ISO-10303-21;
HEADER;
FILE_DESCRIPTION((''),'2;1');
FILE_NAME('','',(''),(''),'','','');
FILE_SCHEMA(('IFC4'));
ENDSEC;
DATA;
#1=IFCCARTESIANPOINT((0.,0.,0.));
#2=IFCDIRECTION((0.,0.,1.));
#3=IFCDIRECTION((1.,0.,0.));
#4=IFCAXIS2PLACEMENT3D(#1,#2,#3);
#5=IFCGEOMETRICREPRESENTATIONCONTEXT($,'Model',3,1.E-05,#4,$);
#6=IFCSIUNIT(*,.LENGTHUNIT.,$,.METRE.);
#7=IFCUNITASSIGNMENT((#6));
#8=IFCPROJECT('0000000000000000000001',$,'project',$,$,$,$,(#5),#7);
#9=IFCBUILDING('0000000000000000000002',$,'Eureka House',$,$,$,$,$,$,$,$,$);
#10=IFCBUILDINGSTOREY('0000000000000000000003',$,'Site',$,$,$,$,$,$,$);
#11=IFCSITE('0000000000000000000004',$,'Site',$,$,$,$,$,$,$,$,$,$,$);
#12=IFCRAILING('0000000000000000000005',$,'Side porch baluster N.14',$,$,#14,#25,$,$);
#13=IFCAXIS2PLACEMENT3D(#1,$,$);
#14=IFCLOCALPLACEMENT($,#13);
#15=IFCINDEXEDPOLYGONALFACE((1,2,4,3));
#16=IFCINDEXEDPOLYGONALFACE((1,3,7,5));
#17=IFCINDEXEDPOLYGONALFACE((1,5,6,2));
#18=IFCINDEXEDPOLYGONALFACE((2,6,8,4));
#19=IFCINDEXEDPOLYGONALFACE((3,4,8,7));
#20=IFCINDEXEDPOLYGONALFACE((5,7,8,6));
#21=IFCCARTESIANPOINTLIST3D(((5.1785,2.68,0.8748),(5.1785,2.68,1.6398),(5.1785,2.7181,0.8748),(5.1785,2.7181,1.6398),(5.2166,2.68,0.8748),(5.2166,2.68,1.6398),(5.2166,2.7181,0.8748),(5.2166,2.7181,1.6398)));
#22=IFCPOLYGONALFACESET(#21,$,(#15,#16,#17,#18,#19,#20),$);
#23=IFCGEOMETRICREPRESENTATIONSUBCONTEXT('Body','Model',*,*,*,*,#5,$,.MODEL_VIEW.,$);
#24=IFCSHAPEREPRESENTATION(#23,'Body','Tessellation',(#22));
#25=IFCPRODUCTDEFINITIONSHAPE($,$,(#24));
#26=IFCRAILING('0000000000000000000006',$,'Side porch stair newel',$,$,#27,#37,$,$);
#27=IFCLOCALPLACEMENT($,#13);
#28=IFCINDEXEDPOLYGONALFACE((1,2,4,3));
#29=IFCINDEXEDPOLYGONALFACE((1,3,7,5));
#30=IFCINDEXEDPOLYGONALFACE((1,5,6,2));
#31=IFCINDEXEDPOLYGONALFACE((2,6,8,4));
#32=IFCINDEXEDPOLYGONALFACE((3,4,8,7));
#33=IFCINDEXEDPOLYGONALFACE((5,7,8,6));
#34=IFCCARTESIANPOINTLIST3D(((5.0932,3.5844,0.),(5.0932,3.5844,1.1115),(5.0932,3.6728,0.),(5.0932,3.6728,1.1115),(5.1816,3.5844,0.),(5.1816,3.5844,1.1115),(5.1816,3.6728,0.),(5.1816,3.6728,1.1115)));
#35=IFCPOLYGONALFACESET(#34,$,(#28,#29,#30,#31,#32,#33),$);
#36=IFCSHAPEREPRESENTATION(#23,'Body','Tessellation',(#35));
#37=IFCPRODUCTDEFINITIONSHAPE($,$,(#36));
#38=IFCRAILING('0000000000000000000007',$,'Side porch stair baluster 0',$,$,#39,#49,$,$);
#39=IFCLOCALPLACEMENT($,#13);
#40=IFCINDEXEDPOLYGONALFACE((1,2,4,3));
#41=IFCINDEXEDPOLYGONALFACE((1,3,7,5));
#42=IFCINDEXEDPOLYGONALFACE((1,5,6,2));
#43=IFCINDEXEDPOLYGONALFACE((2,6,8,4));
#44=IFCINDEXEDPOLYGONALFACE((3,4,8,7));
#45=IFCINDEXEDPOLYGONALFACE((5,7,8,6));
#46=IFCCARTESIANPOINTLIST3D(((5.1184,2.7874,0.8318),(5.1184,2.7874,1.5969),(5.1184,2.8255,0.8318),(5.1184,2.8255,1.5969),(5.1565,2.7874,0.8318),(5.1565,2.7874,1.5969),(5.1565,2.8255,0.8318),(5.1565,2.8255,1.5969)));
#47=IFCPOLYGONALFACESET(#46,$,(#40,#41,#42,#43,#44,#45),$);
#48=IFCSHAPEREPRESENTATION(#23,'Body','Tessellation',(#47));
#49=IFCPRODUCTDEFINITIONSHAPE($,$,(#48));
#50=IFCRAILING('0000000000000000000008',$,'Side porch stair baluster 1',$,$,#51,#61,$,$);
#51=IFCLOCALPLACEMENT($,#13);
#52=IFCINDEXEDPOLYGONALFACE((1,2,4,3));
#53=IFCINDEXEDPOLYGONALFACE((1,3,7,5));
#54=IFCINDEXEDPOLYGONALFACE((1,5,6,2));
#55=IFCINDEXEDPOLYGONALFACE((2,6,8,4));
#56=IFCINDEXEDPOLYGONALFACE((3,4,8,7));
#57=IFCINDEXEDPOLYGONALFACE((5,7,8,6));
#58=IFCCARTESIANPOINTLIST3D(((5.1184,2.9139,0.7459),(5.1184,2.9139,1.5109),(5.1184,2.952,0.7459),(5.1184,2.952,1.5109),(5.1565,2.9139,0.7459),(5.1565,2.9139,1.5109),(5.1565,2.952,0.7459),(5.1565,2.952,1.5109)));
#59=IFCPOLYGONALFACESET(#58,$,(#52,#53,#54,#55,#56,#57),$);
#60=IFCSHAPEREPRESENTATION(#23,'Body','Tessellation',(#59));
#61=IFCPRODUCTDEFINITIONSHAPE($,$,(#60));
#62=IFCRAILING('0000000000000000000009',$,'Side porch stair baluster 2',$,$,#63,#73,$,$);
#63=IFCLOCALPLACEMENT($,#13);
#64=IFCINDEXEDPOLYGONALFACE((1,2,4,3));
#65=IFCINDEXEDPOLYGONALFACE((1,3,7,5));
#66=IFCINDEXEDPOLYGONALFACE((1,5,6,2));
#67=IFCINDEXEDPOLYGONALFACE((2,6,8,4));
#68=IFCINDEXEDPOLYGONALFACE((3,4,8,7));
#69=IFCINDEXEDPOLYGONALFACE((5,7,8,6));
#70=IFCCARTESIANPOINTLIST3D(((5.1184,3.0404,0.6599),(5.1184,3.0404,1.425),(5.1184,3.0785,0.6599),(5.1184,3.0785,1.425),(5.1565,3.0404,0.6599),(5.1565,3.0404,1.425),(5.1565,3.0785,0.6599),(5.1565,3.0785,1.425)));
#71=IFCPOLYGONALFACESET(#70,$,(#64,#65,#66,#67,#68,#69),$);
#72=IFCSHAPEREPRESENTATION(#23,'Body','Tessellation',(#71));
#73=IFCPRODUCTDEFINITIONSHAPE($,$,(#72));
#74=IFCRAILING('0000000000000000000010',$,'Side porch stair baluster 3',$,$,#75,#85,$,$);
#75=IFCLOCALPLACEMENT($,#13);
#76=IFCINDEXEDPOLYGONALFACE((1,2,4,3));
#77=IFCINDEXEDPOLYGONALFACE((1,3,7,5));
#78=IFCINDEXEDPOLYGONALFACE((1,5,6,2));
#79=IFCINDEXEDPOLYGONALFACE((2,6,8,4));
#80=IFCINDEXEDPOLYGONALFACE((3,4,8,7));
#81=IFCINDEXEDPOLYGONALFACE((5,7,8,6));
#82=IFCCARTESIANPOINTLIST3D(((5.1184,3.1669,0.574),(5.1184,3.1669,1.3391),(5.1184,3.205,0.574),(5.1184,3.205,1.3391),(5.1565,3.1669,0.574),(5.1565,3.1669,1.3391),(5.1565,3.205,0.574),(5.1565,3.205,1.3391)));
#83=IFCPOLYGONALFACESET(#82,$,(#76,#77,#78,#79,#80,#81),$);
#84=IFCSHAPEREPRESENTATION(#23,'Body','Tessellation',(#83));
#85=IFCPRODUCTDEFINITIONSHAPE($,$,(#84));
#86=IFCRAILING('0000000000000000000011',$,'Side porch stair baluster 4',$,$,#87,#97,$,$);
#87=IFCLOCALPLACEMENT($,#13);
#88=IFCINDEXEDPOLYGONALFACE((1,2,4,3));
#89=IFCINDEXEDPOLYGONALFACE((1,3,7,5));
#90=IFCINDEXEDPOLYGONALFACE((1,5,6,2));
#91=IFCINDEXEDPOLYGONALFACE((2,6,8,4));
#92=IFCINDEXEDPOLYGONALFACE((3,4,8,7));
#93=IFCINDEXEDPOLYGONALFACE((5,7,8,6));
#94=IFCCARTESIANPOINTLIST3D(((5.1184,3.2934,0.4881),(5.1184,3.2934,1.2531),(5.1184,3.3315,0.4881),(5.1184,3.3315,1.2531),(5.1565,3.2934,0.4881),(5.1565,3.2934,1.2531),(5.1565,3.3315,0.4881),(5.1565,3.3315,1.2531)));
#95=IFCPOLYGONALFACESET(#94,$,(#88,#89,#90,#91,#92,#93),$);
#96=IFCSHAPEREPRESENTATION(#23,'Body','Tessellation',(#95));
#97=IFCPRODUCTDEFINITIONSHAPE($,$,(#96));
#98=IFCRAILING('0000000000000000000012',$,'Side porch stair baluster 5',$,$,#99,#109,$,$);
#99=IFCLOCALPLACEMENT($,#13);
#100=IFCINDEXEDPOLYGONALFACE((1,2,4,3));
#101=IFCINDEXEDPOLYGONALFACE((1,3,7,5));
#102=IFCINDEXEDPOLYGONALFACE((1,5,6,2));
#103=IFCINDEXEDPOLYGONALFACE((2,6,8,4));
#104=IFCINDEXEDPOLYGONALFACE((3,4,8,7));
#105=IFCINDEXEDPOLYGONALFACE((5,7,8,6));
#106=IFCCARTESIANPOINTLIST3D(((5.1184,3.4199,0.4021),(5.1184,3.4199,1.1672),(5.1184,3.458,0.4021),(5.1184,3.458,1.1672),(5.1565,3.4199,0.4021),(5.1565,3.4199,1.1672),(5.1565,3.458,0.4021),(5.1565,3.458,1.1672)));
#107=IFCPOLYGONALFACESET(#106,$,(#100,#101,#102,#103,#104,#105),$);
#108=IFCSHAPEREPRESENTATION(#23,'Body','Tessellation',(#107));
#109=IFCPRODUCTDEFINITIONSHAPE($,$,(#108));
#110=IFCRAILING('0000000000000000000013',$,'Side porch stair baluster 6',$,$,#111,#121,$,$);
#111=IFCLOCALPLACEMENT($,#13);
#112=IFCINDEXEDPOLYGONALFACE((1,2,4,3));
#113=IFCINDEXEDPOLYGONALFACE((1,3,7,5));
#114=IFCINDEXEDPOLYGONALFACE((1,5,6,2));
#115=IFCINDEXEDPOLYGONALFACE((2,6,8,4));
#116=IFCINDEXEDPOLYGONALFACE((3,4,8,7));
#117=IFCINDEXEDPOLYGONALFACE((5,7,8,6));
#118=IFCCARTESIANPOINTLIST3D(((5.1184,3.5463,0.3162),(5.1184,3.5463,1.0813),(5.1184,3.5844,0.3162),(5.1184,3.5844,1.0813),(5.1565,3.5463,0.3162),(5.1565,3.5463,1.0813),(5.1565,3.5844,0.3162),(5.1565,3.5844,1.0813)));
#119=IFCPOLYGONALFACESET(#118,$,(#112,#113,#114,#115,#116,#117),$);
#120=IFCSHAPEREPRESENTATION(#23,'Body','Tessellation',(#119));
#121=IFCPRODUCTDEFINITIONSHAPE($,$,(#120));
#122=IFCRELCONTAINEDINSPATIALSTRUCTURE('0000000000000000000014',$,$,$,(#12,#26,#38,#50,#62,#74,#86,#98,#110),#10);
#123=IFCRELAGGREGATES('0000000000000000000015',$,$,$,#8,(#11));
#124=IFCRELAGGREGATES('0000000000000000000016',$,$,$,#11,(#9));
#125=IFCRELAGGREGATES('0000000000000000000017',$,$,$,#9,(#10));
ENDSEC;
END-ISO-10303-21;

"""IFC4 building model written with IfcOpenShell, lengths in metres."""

from ifc_helpers import new_model, si_unit, frame, origin, origin_with_axes, origin_2d, place, context, subcontext, project, spatial, rectangle, extrude, element, save


model = new_model("IFC4")

# Units and contexts
model_context = context("Model", 3, precision=1e-05, world=origin_with_axes())
body_context = subcontext(model_context, "Body", "Model", "MODEL_VIEW")
ifc_project = project(units=[si_unit("LENGTHUNIT", "METRE")], contexts=[model_context])

# Site, building, storey
site = spatial("IfcSite", under=ifc_project, Name="Site")
building = spatial("IfcBuilding", under=site, Name="Eureka House")
storey = spatial("IfcBuildingStorey", under=building, Name="Site")

# Railings
for number, where, z_axis, x_axis, name in (
    (1, (5.1975, 2.699, 0.8748), (0.0, 0.0, 1.0), (1.0, 0.0, 0.0), "Side porch baluster N.14"),
):
    element("IfcRailing", number, at=place(None, frame(where, z_axis=z_axis, x_axis=x_axis)), inside=storey, Name=name, context=body_context, shape_type="SweptSolid", body=[
        extrude(rectangle(XDim=0.0381, YDim=0.0381, at=origin_2d()), origin(), (0.0, 0.0, 1.0), 0.765),
    ])
railing_1_placement = place(None, frame((5.1374, 3.6286, 0.0), z_axis=(0.0, 0.0, 1.0), x_axis=(1.0, 0.0, 0.0)))
element("IfcRailing", 2, at=railing_1_placement, inside=storey, Name="Side porch stair newel", context=body_context, shape_type="SweptSolid", body=[
    extrude(rectangle(XDim=0.0884, YDim=0.0884, at=origin_2d()), origin(), (0.0, 0.0, 1.0), 1.1115),
])
for number, where, z_axis, x_axis, name in (
    (3, (5.1374, 2.8064, 0.8318), (0.0, 0.0, 1.0), (1.0, 0.0, 0.0), "Side porch stair baluster 0"),
    (4, (5.1374, 2.9329, 0.7459), (0.0, 0.0, 1.0), (1.0, 0.0, 0.0), "Side porch stair baluster 1"),
    (5, (5.1374, 3.0594, 0.6599), (0.0, 0.0, 1.0), (1.0, 0.0, 0.0), "Side porch stair baluster 2"),
    (6, (5.1374, 3.1859, 0.574), (0.0, 0.0, 1.0), (1.0, 0.0, 0.0), "Side porch stair baluster 3"),
    (7, (5.1374, 3.3124, 0.4881), (0.0, 0.0, 1.0), (1.0, 0.0, 0.0), "Side porch stair baluster 4"),
    (8, (5.1374, 3.4389, 0.4021), (0.0, 0.0, 1.0), (1.0, 0.0, 0.0), "Side porch stair baluster 5"),
    (9, (5.1374, 3.5654, 0.3162), (0.0, 0.0, 1.0), (1.0, 0.0, 0.0), "Side porch stair baluster 6"),
):
    element("IfcRailing", number, at=place(None, frame(where, z_axis=z_axis, x_axis=x_axis)), inside=storey, Name=name, context=body_context, shape_type="SweptSolid", body=[
        extrude(rectangle(XDim=0.0381, YDim=0.0381, at=origin_2d()), origin(), (0.0, 0.0, 1.0), 0.765),
    ])

save(model, "model.ifc")
